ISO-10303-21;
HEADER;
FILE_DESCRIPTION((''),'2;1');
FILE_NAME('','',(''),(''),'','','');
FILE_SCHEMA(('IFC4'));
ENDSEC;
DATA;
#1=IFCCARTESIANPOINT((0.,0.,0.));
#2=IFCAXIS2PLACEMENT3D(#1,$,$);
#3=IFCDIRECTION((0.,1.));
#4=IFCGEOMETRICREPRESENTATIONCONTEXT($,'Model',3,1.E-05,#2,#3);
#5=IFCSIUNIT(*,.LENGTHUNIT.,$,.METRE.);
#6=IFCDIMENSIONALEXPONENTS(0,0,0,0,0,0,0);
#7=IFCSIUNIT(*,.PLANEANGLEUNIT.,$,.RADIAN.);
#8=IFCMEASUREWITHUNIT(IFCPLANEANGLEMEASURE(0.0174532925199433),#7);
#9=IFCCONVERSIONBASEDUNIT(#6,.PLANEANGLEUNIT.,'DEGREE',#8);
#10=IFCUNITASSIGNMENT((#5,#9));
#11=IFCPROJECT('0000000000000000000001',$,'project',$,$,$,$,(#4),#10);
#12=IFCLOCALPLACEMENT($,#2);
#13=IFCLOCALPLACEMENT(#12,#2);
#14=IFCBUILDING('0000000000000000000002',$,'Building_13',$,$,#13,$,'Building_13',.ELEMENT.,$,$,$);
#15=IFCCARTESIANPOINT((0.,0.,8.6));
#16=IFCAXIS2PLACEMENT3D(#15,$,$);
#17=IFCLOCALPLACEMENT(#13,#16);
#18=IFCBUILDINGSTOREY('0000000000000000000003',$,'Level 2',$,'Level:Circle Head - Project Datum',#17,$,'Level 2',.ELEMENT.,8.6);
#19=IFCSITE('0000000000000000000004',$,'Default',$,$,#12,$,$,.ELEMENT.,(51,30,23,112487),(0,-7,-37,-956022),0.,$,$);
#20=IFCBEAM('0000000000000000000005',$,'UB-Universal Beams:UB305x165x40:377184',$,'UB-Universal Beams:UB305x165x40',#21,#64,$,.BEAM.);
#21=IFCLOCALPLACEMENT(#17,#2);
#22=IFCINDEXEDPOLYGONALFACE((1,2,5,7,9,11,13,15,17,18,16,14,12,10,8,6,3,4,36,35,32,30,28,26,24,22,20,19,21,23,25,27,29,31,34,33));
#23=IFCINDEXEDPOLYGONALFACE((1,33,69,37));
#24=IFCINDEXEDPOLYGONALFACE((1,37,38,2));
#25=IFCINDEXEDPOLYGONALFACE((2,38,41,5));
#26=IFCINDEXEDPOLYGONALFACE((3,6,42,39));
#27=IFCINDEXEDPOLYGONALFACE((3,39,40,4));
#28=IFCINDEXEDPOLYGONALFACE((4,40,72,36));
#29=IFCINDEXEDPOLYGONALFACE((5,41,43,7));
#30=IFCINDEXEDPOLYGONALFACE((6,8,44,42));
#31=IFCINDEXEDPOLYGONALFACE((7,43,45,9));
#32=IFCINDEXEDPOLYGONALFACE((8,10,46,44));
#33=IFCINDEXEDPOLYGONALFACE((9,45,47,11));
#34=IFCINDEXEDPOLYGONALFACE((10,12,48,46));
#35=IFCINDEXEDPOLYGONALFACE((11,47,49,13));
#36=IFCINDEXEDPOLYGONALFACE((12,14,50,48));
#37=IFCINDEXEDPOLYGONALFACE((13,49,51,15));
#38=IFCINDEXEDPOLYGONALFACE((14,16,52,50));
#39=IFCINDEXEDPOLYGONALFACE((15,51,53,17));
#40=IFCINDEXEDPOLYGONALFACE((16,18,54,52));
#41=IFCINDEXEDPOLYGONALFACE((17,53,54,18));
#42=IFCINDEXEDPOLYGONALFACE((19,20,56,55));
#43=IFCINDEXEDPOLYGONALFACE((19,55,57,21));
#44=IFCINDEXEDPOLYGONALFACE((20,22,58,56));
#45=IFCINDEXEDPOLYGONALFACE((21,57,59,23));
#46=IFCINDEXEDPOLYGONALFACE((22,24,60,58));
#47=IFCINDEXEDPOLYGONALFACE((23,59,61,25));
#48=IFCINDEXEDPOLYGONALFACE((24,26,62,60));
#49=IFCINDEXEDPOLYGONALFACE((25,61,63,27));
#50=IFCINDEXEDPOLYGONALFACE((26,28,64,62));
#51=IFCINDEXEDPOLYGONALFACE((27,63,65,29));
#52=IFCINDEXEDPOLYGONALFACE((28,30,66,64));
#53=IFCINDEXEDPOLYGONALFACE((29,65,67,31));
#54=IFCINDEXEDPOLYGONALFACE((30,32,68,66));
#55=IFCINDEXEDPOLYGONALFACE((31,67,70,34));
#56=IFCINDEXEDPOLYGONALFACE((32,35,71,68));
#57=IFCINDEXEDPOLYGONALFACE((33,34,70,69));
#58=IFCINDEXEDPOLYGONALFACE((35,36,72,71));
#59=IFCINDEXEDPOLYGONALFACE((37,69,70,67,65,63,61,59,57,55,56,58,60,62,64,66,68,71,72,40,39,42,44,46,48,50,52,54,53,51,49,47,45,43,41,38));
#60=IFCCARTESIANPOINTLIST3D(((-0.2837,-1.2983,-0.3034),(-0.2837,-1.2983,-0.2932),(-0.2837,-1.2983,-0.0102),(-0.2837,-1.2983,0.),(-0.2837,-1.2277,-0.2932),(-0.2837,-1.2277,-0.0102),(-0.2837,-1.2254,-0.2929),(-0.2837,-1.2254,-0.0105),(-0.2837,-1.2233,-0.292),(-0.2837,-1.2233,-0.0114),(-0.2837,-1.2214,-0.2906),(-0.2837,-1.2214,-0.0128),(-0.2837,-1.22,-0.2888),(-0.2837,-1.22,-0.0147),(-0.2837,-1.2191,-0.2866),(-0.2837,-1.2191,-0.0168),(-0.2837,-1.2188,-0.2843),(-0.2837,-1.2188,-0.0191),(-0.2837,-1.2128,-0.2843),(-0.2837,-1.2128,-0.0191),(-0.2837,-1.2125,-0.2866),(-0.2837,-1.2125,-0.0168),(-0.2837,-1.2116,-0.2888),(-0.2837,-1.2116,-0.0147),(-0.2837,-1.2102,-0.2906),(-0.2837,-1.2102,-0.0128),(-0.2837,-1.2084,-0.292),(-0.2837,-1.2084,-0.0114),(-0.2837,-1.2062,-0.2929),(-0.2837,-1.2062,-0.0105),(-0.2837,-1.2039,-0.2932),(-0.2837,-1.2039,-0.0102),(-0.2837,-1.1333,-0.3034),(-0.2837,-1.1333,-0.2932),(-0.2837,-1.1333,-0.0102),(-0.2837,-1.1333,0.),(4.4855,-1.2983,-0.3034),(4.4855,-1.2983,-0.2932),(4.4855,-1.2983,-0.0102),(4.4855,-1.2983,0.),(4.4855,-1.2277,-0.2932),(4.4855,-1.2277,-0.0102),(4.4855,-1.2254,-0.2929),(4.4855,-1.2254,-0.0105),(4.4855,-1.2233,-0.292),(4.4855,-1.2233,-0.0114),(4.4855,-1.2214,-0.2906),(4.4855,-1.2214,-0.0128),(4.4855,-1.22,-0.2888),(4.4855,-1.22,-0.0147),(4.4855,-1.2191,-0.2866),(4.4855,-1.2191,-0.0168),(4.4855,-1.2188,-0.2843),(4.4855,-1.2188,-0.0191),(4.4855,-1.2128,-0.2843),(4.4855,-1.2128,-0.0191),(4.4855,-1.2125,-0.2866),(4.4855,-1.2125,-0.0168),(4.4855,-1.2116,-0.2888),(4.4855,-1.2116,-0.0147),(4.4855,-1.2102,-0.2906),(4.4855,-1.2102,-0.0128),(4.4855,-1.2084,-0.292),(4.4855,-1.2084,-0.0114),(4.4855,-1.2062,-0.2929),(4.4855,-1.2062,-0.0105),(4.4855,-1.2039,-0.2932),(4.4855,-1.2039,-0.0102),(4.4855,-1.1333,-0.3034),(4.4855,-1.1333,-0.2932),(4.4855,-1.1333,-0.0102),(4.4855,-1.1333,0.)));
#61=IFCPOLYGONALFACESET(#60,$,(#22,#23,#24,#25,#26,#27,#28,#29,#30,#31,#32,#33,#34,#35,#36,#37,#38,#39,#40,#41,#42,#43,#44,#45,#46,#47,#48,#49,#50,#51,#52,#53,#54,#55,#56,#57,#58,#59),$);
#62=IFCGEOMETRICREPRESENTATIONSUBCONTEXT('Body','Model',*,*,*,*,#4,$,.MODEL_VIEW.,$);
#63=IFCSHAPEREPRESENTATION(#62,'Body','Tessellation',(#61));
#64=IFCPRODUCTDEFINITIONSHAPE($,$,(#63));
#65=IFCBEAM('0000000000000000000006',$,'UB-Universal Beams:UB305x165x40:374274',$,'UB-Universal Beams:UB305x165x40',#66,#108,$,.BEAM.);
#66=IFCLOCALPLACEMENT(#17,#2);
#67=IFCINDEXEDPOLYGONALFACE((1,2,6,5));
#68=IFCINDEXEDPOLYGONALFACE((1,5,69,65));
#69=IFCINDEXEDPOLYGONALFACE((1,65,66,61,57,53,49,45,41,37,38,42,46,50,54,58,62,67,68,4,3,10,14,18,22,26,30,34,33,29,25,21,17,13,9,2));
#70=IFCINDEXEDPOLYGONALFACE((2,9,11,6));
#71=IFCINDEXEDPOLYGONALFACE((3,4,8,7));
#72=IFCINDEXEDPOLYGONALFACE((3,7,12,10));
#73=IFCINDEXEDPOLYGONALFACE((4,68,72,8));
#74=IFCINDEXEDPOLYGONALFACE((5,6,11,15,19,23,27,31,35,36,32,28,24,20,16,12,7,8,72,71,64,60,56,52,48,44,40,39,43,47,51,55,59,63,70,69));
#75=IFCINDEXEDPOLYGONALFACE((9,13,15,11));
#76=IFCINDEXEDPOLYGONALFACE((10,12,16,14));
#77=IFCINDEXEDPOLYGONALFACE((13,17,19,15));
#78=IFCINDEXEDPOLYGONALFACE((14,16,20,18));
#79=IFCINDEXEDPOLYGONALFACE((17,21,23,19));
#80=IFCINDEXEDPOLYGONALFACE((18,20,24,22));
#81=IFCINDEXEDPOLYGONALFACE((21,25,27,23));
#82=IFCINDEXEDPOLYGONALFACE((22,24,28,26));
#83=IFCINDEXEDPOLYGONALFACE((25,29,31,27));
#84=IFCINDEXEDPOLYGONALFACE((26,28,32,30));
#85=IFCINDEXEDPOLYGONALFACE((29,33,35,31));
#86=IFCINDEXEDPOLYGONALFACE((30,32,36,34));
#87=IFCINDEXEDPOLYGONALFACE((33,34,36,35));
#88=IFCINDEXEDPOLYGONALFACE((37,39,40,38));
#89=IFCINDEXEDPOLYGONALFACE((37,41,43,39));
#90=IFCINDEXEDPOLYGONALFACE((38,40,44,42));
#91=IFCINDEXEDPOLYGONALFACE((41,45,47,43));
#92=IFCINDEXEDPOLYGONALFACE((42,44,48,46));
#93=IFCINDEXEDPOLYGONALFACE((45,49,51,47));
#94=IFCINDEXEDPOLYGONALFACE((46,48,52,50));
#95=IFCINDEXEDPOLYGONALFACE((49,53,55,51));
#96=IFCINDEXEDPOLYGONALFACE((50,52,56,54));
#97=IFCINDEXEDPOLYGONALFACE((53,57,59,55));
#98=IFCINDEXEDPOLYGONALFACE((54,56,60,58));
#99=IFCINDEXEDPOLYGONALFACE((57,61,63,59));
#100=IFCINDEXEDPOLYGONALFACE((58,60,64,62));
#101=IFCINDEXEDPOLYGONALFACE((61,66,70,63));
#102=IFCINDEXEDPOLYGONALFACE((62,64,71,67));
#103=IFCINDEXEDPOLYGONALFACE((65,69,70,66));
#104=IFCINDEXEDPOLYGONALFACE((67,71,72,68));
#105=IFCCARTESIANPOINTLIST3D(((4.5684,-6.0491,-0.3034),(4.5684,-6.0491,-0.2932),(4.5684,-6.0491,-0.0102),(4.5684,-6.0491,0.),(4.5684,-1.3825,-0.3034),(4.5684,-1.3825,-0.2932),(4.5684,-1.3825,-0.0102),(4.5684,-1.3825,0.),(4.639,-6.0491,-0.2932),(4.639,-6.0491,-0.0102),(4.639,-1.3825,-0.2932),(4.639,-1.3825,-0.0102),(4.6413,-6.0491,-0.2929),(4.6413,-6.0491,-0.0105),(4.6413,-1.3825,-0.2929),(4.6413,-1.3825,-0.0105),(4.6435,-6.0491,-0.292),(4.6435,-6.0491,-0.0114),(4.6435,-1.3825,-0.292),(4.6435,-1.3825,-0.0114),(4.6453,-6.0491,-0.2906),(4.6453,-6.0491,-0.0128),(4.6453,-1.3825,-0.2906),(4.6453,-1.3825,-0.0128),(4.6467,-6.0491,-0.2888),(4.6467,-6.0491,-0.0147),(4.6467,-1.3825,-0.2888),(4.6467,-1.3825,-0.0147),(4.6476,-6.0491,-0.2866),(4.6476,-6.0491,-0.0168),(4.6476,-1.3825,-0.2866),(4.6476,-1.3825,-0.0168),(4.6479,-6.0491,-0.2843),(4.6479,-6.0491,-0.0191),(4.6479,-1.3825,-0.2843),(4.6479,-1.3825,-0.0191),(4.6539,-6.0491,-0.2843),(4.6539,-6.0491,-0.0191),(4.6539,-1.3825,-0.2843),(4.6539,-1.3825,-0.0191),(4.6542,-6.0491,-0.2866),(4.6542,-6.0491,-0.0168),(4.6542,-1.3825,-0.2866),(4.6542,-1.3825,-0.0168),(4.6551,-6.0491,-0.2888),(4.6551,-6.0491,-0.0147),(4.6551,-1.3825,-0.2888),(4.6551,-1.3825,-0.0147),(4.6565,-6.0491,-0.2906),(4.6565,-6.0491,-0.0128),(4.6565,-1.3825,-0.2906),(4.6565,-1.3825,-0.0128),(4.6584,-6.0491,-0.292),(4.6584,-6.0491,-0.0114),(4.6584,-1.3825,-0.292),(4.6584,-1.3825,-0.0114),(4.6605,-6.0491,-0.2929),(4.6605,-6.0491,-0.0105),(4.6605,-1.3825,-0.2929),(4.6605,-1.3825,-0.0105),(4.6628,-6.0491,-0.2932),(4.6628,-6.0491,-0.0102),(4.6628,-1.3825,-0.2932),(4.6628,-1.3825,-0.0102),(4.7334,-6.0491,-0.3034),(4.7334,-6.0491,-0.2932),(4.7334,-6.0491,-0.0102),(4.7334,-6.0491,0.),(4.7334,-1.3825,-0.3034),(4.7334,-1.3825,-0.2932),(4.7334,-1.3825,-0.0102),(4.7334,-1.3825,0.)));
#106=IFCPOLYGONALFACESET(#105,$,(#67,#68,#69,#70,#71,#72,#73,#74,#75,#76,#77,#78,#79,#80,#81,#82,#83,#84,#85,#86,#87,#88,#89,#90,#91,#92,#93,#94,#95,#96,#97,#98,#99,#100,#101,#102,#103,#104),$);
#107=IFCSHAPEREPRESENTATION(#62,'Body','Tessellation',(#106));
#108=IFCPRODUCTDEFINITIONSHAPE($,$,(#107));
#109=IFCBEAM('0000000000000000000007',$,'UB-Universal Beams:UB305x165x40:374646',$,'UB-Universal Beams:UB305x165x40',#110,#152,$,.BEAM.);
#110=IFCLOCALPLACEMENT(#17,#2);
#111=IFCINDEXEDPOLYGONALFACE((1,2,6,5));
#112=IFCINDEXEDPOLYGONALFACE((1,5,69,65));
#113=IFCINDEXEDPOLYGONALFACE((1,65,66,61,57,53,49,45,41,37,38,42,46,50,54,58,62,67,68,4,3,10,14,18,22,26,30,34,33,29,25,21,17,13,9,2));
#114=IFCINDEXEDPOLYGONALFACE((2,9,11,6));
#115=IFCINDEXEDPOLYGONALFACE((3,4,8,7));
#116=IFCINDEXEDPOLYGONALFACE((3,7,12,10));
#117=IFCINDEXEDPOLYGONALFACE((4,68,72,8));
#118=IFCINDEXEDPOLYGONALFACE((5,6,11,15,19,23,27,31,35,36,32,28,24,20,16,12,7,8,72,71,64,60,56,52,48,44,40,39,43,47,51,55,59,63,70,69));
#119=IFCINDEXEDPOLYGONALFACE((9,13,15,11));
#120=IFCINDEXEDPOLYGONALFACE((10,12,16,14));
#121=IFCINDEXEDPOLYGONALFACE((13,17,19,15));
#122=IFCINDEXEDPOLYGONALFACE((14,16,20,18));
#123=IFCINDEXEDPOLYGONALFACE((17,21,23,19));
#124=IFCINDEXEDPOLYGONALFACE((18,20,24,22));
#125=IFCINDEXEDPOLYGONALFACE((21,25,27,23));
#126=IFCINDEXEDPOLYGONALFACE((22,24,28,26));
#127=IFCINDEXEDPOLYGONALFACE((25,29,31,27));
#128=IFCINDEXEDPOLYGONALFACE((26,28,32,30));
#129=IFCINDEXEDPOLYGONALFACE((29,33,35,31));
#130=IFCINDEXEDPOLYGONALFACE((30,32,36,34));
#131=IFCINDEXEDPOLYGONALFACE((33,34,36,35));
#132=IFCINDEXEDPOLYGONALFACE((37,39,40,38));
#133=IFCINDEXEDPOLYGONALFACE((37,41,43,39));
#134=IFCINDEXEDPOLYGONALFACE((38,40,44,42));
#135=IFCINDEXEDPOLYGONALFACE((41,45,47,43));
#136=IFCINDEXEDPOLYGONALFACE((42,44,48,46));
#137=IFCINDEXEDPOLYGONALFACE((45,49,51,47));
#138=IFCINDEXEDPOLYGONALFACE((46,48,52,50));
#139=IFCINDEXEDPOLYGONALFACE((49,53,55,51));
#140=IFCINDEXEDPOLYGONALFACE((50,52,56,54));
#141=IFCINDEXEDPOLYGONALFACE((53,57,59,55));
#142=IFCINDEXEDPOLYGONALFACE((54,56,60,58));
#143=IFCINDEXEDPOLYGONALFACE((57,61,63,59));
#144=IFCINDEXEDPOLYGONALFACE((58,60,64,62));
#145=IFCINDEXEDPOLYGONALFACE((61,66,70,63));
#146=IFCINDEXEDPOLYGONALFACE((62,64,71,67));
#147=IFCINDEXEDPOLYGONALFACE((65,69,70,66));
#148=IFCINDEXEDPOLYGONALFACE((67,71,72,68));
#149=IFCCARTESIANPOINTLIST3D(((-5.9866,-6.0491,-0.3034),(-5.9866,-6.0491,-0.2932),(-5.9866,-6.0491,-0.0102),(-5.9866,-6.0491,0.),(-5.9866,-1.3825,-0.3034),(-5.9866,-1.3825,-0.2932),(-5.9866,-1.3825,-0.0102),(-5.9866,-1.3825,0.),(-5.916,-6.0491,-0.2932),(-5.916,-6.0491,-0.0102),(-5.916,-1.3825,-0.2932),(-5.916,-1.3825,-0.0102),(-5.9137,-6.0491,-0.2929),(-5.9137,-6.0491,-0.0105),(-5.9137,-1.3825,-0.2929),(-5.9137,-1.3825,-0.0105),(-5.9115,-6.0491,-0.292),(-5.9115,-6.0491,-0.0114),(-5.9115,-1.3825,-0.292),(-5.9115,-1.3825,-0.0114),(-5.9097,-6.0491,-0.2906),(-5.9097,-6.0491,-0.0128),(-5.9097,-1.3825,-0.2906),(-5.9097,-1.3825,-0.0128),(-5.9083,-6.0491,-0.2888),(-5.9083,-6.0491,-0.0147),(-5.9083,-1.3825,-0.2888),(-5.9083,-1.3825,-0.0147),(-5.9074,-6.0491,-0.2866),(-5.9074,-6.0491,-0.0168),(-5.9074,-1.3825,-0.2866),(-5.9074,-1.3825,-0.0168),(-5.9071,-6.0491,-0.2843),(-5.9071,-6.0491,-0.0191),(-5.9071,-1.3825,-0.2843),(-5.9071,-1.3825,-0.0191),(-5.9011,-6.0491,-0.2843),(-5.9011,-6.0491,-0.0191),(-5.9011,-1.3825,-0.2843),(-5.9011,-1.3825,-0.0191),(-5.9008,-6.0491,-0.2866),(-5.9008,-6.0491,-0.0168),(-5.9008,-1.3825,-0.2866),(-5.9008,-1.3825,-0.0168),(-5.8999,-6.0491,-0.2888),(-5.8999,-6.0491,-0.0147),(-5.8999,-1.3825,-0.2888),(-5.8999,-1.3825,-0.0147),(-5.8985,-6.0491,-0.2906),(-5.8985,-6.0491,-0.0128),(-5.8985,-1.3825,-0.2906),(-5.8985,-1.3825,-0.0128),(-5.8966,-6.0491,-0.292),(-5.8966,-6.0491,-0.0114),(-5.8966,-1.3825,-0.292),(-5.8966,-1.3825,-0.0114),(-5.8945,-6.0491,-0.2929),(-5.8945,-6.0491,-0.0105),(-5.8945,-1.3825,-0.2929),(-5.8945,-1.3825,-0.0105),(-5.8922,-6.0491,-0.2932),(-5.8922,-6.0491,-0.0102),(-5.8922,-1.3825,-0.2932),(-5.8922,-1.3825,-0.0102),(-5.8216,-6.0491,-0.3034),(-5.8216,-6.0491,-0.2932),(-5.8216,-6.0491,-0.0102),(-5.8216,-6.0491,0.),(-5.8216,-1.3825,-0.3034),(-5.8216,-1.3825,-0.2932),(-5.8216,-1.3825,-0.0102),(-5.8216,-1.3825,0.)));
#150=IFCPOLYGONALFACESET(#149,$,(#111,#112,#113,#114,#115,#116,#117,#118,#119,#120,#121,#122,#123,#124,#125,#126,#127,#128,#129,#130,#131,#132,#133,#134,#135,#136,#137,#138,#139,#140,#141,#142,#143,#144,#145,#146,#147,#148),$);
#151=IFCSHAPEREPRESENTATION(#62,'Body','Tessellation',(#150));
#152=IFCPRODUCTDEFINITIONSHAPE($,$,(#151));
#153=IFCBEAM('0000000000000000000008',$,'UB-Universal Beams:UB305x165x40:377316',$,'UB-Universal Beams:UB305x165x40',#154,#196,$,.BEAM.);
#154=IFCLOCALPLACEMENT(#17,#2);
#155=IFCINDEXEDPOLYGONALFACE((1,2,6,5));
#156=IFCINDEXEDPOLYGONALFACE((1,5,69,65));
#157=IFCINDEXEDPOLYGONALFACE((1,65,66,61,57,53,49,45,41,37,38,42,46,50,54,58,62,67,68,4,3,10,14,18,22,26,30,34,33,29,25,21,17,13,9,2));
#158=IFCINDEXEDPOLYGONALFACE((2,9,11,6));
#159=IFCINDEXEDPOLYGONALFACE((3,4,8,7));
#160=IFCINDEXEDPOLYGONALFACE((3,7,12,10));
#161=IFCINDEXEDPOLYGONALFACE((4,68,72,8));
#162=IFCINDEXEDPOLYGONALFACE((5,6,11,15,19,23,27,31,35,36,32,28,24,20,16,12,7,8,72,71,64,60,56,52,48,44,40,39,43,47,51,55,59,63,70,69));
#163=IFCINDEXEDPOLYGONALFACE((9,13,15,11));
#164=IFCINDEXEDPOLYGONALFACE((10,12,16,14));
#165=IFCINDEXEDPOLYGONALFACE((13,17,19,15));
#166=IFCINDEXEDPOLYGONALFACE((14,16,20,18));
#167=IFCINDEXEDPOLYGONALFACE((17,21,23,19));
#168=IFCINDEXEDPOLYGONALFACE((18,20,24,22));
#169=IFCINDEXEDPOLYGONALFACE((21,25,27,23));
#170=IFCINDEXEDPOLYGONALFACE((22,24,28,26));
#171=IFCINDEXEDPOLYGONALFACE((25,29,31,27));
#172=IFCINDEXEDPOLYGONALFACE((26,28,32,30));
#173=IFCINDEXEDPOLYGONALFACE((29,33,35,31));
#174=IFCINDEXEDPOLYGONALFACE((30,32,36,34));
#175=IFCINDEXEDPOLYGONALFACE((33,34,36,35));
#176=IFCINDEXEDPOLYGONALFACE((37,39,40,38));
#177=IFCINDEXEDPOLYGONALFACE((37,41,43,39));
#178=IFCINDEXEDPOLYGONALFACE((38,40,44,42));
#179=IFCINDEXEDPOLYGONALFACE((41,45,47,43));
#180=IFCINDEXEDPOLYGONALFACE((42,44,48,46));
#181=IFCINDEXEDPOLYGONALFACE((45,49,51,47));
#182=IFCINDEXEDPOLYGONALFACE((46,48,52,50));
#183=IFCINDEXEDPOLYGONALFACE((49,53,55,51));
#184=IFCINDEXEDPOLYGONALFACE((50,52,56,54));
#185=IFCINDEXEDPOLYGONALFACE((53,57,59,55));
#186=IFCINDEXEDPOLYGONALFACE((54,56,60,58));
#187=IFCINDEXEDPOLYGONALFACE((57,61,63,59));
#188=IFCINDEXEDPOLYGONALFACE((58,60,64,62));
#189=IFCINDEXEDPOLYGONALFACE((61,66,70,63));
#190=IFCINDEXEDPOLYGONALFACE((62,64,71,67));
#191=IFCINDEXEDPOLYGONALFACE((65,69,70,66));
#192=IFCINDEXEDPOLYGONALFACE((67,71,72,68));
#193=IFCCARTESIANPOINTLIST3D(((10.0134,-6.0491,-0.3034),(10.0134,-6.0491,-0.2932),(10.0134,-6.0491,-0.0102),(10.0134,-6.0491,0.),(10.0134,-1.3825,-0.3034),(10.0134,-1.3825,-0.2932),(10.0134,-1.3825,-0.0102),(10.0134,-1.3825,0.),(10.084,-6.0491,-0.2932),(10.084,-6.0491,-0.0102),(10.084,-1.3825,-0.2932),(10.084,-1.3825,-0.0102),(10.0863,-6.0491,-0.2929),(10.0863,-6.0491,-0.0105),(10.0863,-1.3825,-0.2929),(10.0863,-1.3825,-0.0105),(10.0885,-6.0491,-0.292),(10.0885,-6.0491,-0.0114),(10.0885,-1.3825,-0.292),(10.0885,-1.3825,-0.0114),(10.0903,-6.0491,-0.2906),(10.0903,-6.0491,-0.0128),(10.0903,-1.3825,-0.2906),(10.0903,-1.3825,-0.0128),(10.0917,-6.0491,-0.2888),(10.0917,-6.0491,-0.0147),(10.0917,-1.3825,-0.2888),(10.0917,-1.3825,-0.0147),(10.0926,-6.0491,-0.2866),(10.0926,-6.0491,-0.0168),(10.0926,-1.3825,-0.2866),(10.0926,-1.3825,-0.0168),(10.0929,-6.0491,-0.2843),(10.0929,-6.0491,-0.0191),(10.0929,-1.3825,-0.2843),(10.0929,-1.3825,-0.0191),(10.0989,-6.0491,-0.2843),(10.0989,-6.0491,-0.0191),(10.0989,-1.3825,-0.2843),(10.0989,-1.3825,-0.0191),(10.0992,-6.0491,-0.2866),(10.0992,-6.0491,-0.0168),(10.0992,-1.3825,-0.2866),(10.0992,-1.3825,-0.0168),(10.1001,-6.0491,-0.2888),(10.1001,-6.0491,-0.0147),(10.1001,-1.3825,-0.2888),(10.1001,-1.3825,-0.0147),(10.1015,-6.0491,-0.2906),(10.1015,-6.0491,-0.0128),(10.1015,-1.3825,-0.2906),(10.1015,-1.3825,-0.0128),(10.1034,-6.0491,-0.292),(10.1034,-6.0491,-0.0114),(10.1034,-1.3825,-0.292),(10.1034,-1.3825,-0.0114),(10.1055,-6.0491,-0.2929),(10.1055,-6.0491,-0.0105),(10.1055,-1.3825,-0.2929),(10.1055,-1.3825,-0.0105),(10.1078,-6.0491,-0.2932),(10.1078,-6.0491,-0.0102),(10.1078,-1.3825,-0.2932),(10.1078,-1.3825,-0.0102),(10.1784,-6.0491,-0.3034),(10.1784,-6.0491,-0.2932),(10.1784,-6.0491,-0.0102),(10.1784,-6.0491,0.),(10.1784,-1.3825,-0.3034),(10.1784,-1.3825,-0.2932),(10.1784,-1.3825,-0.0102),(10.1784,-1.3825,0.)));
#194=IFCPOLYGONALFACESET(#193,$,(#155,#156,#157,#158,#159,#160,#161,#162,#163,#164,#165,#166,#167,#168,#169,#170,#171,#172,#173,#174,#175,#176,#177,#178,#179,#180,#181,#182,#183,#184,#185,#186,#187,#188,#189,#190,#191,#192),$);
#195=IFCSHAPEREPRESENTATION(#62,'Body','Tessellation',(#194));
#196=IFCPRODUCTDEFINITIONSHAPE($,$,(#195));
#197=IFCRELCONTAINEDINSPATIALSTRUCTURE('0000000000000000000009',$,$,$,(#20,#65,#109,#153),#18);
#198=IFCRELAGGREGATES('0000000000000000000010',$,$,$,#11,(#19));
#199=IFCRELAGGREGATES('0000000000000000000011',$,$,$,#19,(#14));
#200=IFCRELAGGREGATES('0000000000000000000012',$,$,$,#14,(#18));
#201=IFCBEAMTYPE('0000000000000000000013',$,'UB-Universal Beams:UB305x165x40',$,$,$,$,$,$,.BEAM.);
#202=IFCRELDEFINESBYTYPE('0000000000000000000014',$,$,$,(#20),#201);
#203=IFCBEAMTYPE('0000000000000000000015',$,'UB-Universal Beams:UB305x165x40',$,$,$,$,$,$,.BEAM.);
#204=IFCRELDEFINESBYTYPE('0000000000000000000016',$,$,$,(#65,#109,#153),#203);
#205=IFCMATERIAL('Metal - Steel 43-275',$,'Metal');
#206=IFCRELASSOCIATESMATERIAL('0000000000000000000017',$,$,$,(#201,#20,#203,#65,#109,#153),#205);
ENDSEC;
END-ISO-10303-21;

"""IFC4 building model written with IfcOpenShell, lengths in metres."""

from ifc_helpers import new_model, entity, si_unit, converted_unit, direction, frame, origin, place, context, subcontext, project, spatial, line, arc, indexed_curve, outline, extrude, source, transform, mapped, material, type_object, type_shapes, element, save


model = new_model("IFC4")

# Units and contexts
model_context = context("Model", 3, precision=1e-05, world=origin(), true_north=direction((0.0, 1.0)))
body_context = subcontext(model_context, "Body", "Model", "MODEL_VIEW")
ifc_project = project(units=[si_unit("LENGTHUNIT", "METRE"), converted_unit("PLANEANGLEUNIT", "DEGREE", entity("IfcPlaneAngleMeasure", 0.0174532925199433), si_unit("PLANEANGLEUNIT", "RADIAN"), dimensions=[0, 0, 0, 0, 0, 0, 0])], contexts=[model_context])

# Site, building, storey
site_placement = place(None, origin())
site = spatial("IfcSite", under=ifc_project, at=site_placement, Name="Default", CompositionType="ELEMENT", RefLatitude=(51, 30, 23, 112487), RefLongitude=(0, -7, -37, -956022), RefElevation=0.0)
building_placement = place(site_placement, origin())
building = spatial("IfcBuilding", under=site, at=building_placement, Name="Building_13", LongName="Building_13", CompositionType="ELEMENT")
storey_placement = place(building_placement, frame((0.0, 0.0, 8.6)))
storey = spatial("IfcBuildingStorey", under=building, at=storey_placement, Name="Level 2", ObjectType="Level:Circle Head - Project Datum", LongName="Level 2", CompositionType="ELEMENT", Elevation=8.6)

# Beams
ifc_material_1 = material(Name="Metal - Steel 43-275", Category="Metal")
beam_type_1 = type_object("IfcBeamType", Name="UB-Universal Beams:UB305x165x40", PredefinedType="BEAM", material=ifc_material_1)
shared_shape_1 = source(origin(), body_context, "Body", "SweptSolid", [
    extrude(outline(indexed_curve([(-0.0825, -0.1415), (-0.0825, -0.1517), (0.0825, -0.1517), (0.0825, -0.1415), (0.0119, -0.1415), (0.0056, -0.1389), (0.003, -0.1326), (0.003, 0.1326), (0.0056, 0.1389), (0.0119, 0.1415), (0.0825, 0.1415), (0.0825, 0.1517), (-0.0825, 0.1517), (-0.0825, 0.1415), (-0.0119, 0.1415), (-0.0056, 0.1389), (-0.003, 0.1326), (-0.003, -0.1326), (-0.0056, -0.1389), (-0.0119, -0.1415)], segments=[line(1, 2, 3, 4, 5), arc(5, 6, 7), line(7, 8), arc(8, 9, 10), line(10, 11, 12, 13, 14, 15), arc(15, 16, 17), line(17, 18), arc(18, 19, 20), line(20, 1)], self_intersect=False)), frame((-2.3846, 0.0, 0.0), z_axis=(-1.0, 0.0, 0.0), x_axis=(0.0, -1.0, 0.0)), (0.0, 0.0, -1.0), 4.7692),
])
type_shapes(beam_type_1, [shared_shape_1])
beam_1_placement = place(storey_placement, frame((2.1009, -1.2158, -0.1517), z_axis=(0.0, 0.0, 1.0), x_axis=(-1.0, 0.0, 0.0)))
element("IfcBeam", 1, at=beam_1_placement, inside=storey, type_object=beam_type_1, material=ifc_material_1, Name="UB-Universal Beams:UB305x165x40:377184", ObjectType="UB-Universal Beams:UB305x165x40", PredefinedType="BEAM", context=body_context, shape_type="MappedRepresentation", body=[
    mapped(shared_shape_1, transform((0.0, 0.0, 0.0), scale=1.0)),
])
beam_type_2 = type_object("IfcBeamType", Name="UB-Universal Beams:UB305x165x40", PredefinedType="BEAM", material=ifc_material_1)
shared_shape_2 = source(origin(), body_context, "Body", "SweptSolid", [
    extrude(outline(indexed_curve([(-0.0825, -0.1415), (-0.0825, -0.1517), (0.0825, -0.1517), (0.0825, -0.1415), (0.0119, -0.1415), (0.0056, -0.1389), (0.003, -0.1326), (0.003, 0.1326), (0.0056, 0.1389), (0.0119, 0.1415), (0.0825, 0.1415), (0.0825, 0.1517), (-0.0825, 0.1517), (-0.0825, 0.1415), (-0.0119, 0.1415), (-0.0056, 0.1389), (-0.003, 0.1326), (-0.003, -0.1326), (-0.0056, -0.1389), (-0.0119, -0.1415)], segments=[line(1, 2, 3, 4, 5), arc(5, 6, 7), line(7, 8), arc(8, 9, 10), line(10, 11, 12, 13, 14, 15), arc(15, 16, 17), line(17, 18), arc(18, 19, 20), line(20, 1)], self_intersect=False)), frame((-2.3333, 0.0, 0.0), z_axis=(-1.0, 0.0, 0.0), x_axis=(0.0, -1.0, 0.0)), (0.0, 0.0, -1.0), 4.6666),
])
type_shapes(beam_type_2, [shared_shape_2])
for number, where, z_axis, x_axis, name in (
    (2, (4.6509, -3.7158, -0.1517), (0.0, 0.0, 1.0), (0.0, -1.0, 0.0), "UB-Universal Beams:UB305x165x40:374274"),
    (3, (-5.9041, -3.7158, -0.1517), (0.0, 0.0, 1.0), (0.0, -1.0, 0.0), "UB-Universal Beams:UB305x165x40:374646"),
    (4, (10.0959, -3.7158, -0.1517), (0.0, 0.0, 1.0), (0.0, -1.0, 0.0), "UB-Universal Beams:UB305x165x40:377316"),
):
    element("IfcBeam", number, at=place(storey_placement, frame(where, z_axis=z_axis, x_axis=x_axis)), inside=storey, type_object=beam_type_2, material=ifc_material_1, Name=name, ObjectType="UB-Universal Beams:UB305x165x40", PredefinedType="BEAM", context=body_context, shape_type="MappedRepresentation", body=[
        mapped(shared_shape_2, transform((0.0, 0.0, 0.0), scale=1.0)),
    ])

save(model, "model.ifc")
